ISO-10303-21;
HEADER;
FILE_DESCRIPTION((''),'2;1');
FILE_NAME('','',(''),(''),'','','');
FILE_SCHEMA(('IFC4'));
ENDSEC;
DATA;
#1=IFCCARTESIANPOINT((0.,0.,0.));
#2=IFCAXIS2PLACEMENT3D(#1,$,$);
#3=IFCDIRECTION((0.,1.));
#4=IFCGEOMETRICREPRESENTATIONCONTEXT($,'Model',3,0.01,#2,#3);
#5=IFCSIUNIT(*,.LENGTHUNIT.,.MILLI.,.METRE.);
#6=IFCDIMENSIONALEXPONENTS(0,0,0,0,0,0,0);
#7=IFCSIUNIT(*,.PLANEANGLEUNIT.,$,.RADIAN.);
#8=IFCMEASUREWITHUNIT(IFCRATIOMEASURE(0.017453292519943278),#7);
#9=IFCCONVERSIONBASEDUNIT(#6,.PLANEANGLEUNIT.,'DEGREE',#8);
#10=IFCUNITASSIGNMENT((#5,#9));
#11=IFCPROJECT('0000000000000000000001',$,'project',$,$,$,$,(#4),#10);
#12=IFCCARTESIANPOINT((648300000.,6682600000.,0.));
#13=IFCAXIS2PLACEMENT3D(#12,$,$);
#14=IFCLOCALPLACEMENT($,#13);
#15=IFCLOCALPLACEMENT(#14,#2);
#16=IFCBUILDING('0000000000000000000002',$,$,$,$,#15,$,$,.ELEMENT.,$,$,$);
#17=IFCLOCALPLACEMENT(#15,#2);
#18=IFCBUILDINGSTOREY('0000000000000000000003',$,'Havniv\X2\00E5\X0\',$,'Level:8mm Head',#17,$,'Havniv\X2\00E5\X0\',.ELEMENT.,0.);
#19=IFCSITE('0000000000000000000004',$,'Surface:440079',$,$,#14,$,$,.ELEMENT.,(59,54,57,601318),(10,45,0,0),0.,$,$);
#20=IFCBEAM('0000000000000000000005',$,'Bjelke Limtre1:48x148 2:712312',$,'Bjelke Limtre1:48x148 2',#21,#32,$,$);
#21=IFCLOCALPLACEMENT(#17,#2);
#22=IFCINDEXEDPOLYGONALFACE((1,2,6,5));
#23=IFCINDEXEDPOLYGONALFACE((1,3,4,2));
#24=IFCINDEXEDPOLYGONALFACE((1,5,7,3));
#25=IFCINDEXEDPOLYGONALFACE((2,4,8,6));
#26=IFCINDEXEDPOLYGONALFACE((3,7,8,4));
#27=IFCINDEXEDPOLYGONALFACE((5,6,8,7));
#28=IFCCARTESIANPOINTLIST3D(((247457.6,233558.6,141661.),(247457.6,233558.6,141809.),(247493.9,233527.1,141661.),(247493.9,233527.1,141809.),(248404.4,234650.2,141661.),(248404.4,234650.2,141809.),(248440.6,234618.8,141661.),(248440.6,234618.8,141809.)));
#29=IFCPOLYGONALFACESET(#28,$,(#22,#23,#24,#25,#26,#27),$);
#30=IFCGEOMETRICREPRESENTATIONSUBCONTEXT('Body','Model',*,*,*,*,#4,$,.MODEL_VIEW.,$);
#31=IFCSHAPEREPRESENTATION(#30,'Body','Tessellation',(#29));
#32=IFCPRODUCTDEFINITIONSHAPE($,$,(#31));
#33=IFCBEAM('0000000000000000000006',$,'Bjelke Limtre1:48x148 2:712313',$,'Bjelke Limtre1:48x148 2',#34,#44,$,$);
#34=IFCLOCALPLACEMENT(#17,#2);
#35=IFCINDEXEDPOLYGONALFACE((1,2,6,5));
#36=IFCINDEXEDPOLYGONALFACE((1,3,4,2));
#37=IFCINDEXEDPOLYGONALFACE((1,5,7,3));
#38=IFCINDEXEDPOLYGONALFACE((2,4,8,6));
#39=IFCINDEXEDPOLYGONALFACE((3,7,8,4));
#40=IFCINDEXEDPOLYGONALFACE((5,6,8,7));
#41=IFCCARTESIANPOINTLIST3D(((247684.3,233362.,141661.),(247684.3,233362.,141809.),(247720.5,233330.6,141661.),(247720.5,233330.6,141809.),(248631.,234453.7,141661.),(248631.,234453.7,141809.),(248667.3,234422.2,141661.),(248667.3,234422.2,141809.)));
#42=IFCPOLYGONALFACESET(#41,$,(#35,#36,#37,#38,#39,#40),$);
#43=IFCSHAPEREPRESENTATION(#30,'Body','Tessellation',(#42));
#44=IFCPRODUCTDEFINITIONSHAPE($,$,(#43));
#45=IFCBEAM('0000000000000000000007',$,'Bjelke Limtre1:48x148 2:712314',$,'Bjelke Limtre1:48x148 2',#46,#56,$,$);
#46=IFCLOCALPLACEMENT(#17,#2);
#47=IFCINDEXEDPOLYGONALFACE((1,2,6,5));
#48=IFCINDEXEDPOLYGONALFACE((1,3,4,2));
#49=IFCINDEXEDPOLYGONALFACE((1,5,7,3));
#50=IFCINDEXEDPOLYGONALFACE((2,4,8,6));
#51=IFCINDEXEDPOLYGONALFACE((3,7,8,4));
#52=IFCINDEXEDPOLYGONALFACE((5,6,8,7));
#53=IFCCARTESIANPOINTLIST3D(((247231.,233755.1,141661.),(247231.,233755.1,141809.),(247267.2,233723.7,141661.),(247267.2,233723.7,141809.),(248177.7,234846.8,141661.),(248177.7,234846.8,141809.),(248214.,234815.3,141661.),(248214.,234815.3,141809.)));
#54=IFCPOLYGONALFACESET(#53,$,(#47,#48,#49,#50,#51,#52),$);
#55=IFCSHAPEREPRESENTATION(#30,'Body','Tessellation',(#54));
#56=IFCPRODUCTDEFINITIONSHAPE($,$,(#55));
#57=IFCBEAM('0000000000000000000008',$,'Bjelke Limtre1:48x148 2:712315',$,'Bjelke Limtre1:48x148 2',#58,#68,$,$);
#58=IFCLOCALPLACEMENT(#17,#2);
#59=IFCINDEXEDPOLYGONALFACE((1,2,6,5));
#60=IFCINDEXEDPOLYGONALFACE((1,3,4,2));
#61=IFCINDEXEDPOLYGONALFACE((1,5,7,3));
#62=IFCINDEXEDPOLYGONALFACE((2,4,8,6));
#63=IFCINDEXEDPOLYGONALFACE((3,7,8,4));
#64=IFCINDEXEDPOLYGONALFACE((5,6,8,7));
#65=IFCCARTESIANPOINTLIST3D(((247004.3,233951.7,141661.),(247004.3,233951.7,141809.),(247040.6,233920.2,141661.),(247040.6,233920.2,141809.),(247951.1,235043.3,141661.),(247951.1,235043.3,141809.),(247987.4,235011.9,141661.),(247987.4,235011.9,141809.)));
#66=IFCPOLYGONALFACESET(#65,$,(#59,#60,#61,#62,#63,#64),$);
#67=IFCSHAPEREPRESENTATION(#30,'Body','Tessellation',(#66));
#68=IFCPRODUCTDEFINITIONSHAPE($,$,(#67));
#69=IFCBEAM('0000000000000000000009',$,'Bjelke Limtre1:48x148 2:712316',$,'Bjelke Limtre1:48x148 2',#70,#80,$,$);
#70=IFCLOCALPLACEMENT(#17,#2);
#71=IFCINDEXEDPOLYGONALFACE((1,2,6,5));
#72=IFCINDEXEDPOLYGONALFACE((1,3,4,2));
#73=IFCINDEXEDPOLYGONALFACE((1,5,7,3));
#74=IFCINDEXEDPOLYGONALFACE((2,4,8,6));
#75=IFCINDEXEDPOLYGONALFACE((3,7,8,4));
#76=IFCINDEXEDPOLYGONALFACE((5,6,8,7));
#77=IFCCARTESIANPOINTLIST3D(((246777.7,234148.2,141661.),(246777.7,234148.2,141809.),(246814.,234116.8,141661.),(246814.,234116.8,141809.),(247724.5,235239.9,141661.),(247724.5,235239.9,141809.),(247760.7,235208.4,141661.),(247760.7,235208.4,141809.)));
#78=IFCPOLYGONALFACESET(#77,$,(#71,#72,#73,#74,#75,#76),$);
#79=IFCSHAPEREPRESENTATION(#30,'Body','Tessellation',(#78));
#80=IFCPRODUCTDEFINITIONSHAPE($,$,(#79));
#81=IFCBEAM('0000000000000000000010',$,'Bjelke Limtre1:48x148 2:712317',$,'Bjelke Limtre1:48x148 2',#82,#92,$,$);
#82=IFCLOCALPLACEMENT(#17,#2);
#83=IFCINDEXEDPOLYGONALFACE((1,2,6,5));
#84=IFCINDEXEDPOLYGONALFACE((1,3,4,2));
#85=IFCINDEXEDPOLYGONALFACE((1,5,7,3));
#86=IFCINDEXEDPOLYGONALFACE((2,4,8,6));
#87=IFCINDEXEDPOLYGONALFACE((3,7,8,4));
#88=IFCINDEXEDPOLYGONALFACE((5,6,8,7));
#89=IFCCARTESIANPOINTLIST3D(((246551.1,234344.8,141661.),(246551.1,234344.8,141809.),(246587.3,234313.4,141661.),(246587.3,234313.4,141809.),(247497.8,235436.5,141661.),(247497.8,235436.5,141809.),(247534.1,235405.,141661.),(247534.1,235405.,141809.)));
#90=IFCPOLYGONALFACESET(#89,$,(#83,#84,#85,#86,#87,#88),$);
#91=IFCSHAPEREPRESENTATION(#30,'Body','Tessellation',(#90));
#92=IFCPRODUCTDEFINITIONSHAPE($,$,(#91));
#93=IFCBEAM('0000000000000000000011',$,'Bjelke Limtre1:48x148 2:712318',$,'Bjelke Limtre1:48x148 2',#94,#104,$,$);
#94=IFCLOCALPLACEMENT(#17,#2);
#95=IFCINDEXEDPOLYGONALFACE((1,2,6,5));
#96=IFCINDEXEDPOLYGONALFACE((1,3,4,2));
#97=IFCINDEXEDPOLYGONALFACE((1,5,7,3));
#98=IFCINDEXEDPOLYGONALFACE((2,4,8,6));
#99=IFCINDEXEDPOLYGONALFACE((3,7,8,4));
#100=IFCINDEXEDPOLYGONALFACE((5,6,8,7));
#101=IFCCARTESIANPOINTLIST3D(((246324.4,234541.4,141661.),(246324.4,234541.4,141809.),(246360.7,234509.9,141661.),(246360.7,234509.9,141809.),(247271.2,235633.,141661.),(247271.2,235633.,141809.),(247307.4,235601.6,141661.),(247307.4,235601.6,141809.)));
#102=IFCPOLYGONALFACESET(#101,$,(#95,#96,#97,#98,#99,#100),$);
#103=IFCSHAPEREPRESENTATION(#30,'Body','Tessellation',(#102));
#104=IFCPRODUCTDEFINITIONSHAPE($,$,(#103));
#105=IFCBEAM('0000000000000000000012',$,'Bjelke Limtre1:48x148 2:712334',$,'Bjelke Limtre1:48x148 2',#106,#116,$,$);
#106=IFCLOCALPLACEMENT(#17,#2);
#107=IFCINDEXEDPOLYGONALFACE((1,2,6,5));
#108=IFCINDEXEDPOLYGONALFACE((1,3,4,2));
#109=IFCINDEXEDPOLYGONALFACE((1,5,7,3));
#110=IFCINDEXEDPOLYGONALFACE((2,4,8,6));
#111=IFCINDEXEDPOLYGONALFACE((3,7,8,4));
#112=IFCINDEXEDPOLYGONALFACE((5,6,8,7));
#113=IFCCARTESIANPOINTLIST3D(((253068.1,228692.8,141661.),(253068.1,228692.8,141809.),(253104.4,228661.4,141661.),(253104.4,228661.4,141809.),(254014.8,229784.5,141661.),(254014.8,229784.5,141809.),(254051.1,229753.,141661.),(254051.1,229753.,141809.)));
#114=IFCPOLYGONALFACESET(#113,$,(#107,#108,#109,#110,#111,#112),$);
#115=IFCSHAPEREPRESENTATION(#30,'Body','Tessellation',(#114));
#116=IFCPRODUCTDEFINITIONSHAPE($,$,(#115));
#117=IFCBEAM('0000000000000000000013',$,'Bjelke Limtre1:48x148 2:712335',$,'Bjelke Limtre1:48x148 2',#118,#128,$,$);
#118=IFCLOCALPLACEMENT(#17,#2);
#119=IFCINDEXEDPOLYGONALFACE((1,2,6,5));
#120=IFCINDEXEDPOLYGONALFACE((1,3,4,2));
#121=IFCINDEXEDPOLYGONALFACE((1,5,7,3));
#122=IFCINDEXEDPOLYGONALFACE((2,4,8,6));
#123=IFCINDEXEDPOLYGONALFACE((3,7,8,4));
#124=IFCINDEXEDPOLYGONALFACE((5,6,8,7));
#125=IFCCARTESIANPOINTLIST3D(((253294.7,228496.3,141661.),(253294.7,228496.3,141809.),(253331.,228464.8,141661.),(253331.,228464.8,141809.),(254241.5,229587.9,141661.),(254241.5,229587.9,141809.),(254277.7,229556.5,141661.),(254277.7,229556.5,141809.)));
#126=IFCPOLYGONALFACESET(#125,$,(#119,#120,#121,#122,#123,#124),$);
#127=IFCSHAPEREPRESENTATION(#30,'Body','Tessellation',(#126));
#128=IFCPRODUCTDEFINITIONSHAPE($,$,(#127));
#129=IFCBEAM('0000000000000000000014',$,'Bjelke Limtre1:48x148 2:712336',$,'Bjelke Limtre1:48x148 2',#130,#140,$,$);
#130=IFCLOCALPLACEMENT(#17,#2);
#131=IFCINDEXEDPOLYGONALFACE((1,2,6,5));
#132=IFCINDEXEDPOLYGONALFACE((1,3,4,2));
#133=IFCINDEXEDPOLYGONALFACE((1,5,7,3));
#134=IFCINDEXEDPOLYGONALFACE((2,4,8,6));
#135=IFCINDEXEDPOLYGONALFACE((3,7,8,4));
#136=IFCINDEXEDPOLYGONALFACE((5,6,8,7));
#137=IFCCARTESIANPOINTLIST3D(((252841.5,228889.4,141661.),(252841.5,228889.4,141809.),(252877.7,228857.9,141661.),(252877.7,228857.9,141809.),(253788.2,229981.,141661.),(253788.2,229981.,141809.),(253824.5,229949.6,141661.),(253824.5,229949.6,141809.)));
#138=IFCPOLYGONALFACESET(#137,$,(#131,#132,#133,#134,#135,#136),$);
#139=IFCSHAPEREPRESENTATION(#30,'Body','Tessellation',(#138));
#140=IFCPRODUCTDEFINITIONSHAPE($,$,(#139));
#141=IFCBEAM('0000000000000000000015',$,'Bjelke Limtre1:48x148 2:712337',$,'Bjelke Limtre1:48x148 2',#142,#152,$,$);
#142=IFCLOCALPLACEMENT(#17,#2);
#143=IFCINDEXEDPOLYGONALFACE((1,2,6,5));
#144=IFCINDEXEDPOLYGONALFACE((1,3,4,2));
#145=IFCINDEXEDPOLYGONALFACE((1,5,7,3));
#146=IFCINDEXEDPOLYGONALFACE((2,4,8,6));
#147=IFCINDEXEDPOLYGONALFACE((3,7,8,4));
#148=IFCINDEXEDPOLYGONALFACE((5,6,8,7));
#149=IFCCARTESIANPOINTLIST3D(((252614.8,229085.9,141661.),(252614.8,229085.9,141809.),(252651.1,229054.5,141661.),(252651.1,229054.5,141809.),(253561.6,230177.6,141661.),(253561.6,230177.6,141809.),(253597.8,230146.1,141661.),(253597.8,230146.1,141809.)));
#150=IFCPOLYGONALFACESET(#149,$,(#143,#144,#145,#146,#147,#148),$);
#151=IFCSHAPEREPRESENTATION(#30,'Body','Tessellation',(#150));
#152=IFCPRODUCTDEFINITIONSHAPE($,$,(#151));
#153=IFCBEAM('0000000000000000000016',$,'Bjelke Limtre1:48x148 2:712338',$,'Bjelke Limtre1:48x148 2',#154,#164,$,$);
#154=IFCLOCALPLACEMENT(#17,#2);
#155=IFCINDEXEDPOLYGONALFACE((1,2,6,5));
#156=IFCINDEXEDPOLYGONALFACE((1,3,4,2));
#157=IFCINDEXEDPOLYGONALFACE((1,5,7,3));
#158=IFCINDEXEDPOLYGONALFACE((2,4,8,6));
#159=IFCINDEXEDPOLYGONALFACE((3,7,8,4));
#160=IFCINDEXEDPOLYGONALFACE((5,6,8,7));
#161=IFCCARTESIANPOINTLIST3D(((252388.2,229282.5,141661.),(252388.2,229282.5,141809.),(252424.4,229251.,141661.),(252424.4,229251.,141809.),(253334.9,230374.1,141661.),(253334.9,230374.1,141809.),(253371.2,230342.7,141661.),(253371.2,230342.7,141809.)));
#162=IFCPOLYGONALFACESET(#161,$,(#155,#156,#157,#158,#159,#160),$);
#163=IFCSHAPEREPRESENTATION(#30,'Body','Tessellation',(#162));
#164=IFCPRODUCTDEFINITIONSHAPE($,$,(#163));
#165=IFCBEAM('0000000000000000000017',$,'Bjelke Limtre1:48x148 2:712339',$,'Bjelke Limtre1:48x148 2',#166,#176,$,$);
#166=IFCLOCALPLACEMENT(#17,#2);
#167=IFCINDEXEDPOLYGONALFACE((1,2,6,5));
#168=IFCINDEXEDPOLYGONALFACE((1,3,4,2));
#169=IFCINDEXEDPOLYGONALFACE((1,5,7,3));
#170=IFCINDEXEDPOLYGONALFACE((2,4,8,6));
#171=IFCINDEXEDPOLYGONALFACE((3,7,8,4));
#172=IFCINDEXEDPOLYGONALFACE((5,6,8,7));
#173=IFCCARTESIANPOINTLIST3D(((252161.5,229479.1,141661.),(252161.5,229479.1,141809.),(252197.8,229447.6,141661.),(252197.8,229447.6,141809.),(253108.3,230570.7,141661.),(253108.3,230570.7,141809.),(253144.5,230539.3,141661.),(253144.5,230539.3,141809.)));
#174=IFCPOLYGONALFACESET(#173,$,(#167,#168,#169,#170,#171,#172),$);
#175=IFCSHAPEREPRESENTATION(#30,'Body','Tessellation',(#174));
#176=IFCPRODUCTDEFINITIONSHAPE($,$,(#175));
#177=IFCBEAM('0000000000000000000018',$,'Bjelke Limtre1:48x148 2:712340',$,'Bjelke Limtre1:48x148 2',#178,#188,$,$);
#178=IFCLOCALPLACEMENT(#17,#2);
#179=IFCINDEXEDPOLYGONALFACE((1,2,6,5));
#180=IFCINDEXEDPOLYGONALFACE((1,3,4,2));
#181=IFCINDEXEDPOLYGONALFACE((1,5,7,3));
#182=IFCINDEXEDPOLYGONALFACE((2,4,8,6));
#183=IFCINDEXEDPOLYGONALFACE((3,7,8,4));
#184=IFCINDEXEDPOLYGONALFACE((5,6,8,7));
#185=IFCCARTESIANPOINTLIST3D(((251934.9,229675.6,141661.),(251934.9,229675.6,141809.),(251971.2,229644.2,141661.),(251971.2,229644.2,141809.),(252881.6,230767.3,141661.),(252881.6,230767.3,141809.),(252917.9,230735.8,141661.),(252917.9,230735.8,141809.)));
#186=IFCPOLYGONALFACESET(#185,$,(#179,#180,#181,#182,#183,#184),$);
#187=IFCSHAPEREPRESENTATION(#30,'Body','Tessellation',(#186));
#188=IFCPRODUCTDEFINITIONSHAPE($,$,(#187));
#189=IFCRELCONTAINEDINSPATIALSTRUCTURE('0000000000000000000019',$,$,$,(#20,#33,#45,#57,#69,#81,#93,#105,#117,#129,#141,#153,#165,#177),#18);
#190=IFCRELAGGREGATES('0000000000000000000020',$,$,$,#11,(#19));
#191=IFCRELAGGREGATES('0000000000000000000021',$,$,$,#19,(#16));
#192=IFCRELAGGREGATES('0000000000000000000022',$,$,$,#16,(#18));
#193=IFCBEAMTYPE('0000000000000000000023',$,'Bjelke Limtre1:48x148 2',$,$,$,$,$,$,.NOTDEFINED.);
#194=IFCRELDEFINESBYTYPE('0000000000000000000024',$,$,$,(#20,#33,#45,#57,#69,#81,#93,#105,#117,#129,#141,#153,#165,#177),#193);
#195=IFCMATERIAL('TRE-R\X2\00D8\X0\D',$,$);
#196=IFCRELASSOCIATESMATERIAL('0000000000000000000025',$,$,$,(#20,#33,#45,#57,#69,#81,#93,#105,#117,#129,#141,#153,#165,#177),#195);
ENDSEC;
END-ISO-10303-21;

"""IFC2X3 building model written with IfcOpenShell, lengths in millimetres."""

from ifc_helpers import new_model, entity, si_unit, converted_unit, direction, frame, frame_2d, origin, origin_2d_with_axis, place, context, subcontext, project, spatial, rectangle, extrude, material, type_object, element, save


model = new_model("IFC2X3")

# Units and contexts
model_context = context("Model", 3, precision=0.01, world=origin(), true_north=direction((0.0, 1.0)))
body_context = subcontext(model_context, "Body", "Model", "MODEL_VIEW")
ifc_project = project(units=[si_unit("LENGTHUNIT", "METRE", prefix="MILLI"), converted_unit("PLANEANGLEUNIT", "DEGREE", entity("IfcRatioMeasure", 0.017453292519943278), si_unit("PLANEANGLEUNIT", "RADIAN"), dimensions=[0, 0, 0, 0, 0, 0, 0])], contexts=[model_context])

# Site, building, storey
site_placement = place(None, frame((648300000.0, 6682600000.0, 0.0)))
site = spatial("IfcSite", under=ifc_project, at=site_placement, Name="Surface:440079", CompositionType="ELEMENT", RefLatitude=(59, 54, 57, 601318), RefLongitude=(10, 45, 0, 0), RefElevation=0.0)
building_placement = place(site_placement, origin())
building = spatial("IfcBuilding", under=site, at=building_placement, CompositionType="ELEMENT")
storey_placement = place(building_placement, origin())
storey = spatial("IfcBuildingStorey", under=building, at=storey_placement, Name="Havnivå", ObjectType="Level:8mm Head", LongName="Havnivå", CompositionType="ELEMENT", Elevation=0.0)

# Beams
ifc_material_1 = material(Name="TRE-RØD")
beam_type = type_object("IfcBeamType", Name="Bjelke Limtre1:48x148 2", PredefinedType="NOTDEFINED")
for number, where, z_axis, x_axis, name in (
    (1, (248422.5, 234634.5, 141809.0), (0.0, 0.0, 1.0), (-0.655187, -0.755467, 0.0), "Bjelke Limtre1:48x148 2:712312"),
    (2, (248649.1, 234437.9, 141809.0), (0.0, 0.0, 1.0), (-0.655187, -0.755467, 0.0), "Bjelke Limtre1:48x148 2:712313"),
):
    element("IfcBeam", number, at=place(storey_placement, frame(where, z_axis=z_axis, x_axis=x_axis)), inside=storey, type_object=beam_type, material=ifc_material_1, Name=name, ObjectType="Bjelke Limtre1:48x148 2", context=body_context, shape_type="SweptSolid", body=[
        extrude(rectangle(XDim=148.0, YDim=48.0, at=frame_2d((0.0, 0.0), x_axis=(1.0, 0.0))), frame((0.0, 0.0, -74.0), z_axis=(1.0, 0.0, 0.0), x_axis=(0.0, 0.0, -1.0)), (0.0, 0.0, 1.0), 1445.0),
    ])
beam_1_placement = place(storey_placement, frame((248195.9, 234831.1, 141809.0), z_axis=(0.0, 0.0, 1.0), x_axis=(-0.655187, -0.755467, 0.0)))
element("IfcBeam", 3, at=beam_1_placement, inside=storey, type_object=beam_type, material=ifc_material_1, Name="Bjelke Limtre1:48x148 2:712314", ObjectType="Bjelke Limtre1:48x148 2", context=body_context, shape_type="SweptSolid", body=[
    extrude(rectangle(XDim=148.0, YDim=48.0, at=frame_2d((0.0, 0.0), x_axis=(1.0, 0.0))), frame((0.0, 0.0, -74.0), z_axis=(1.0, 0.0, 0.0), x_axis=(0.0, 0.0, -1.0)), (0.0, 0.0, 1.0), 1445.0),
])
for number, where, z_axis, x_axis, name in (
    (4, (247969.2, 235027.6, 141809.0), (0.0, 0.0, 1.0), (-0.655187, -0.755467, 0.0), "Bjelke Limtre1:48x148 2:712315"),
    (5, (247742.6, 235224.2, 141809.0), (0.0, 0.0, 1.0), (-0.655187, -0.755467, 0.0), "Bjelke Limtre1:48x148 2:712316"),
):
    element("IfcBeam", number, at=place(storey_placement, frame(where, z_axis=z_axis, x_axis=x_axis)), inside=storey, type_object=beam_type, material=ifc_material_1, Name=name, ObjectType="Bjelke Limtre1:48x148 2", context=body_context, shape_type="SweptSolid", body=[
        extrude(rectangle(XDim=148.0, YDim=48.0, at=frame_2d((0.0, 0.0), x_axis=(1.0, 0.0))), frame((0.0, 0.0, -74.0), z_axis=(1.0, 0.0, 0.0), x_axis=(0.0, 0.0, -1.0)), (0.0, 0.0, 1.0), 1445.0),
    ])
beam_2_placement = place(storey_placement, frame((247515.9, 235420.7, 141809.0), z_axis=(0.0, 0.0, 1.0), x_axis=(-0.655187, -0.755467, 0.0)))
element("IfcBeam", 6, at=beam_2_placement, inside=storey, type_object=beam_type, material=ifc_material_1, Name="Bjelke Limtre1:48x148 2:712317", ObjectType="Bjelke Limtre1:48x148 2", context=body_context, shape_type="SweptSolid", body=[
    extrude(rectangle(XDim=148.0, YDim=48.0, at=origin_2d_with_axis()), frame((0.0, 0.0, -74.0), z_axis=(1.0, 0.0, 0.0), x_axis=(0.0, 0.0, -1.0)), (0.0, 0.0, 1.0), 1445.0),
])
beam_3_placement = place(storey_placement, frame((247289.3, 235617.3, 141809.0), z_axis=(0.0, 0.0, 1.0), x_axis=(-0.655187, -0.755467, 0.0)))
element("IfcBeam", 7, at=beam_3_placement, inside=storey, type_object=beam_type, material=ifc_material_1, Name="Bjelke Limtre1:48x148 2:712318", ObjectType="Bjelke Limtre1:48x148 2", context=body_context, shape_type="SweptSolid", body=[
    extrude(rectangle(XDim=148.0, YDim=48.0, at=frame_2d((0.0, 0.0), x_axis=(1.0, 0.0))), frame((0.0, 0.0, -74.0), z_axis=(1.0, 0.0, 0.0), x_axis=(0.0, 0.0, -1.0)), (0.0, 0.0, 1.0), 1445.0),
])
beam_4_placement = place(storey_placement, frame((254033.0, 229768.8, 141809.0), z_axis=(0.0, 0.0, 1.0), x_axis=(-0.655187, -0.755467, 0.0)))
element("IfcBeam", 8, at=beam_4_placement, inside=storey, type_object=beam_type, material=ifc_material_1, Name="Bjelke Limtre1:48x148 2:712334", ObjectType="Bjelke Limtre1:48x148 2", context=body_context, shape_type="SweptSolid", body=[
    extrude(rectangle(XDim=148.0, YDim=48.0, at=frame_2d((0.0, 0.0), x_axis=(1.0, 0.0))), frame((0.0, 0.0, -74.0), z_axis=(1.0, 0.0, 0.0), x_axis=(0.0, 0.0, -1.0)), (0.0, 0.0, 1.0), 1445.0),
])
beam_5_placement = place(storey_placement, frame((254259.6, 229572.2, 141809.0), z_axis=(0.0, 0.0, 1.0), x_axis=(-0.655187, -0.755467, 0.0)))
element("IfcBeam", 9, at=beam_5_placement, inside=storey, type_object=beam_type, material=ifc_material_1, Name="Bjelke Limtre1:48x148 2:712335", ObjectType="Bjelke Limtre1:48x148 2", context=body_context, shape_type="SweptSolid", body=[
    extrude(rectangle(XDim=148.0, YDim=48.0, at=origin_2d_with_axis()), frame((0.0, 0.0, -74.0), z_axis=(1.0, 0.0, 0.0), x_axis=(0.0, 0.0, -1.0)), (0.0, 0.0, 1.0), 1445.0),
])
beam_6_placement = place(storey_placement, frame((253806.3, 229965.3, 141809.0), z_axis=(0.0, 0.0, 1.0), x_axis=(-0.655187, -0.755467, 0.0)))
element("IfcBeam", 10, at=beam_6_placement, inside=storey, type_object=beam_type, material=ifc_material_1, Name="Bjelke Limtre1:48x148 2:712336", ObjectType="Bjelke Limtre1:48x148 2", context=body_context, shape_type="SweptSolid", body=[
    extrude(rectangle(XDim=148.0, YDim=48.0, at=frame_2d((0.0, 0.0), x_axis=(1.0, 0.0))), frame((0.0, 0.0, -74.0), z_axis=(1.0, 0.0, 0.0), x_axis=(0.0, 0.0, -1.0)), (0.0, 0.0, 1.0), 1445.0),
])
beam_7_placement = place(storey_placement, frame((253579.7, 230161.9, 141809.0), z_axis=(0.0, 0.0, 1.0), x_axis=(-0.655187, -0.755467, 0.0)))
element("IfcBeam", 11, at=beam_7_placement, inside=storey, type_object=beam_type, material=ifc_material_1, Name="Bjelke Limtre1:48x148 2:712337", ObjectType="Bjelke Limtre1:48x148 2", context=body_context, shape_type="SweptSolid", body=[
    extrude(rectangle(XDim=148.0, YDim=48.0, at=origin_2d_with_axis()), frame((0.0, 0.0, -74.0), z_axis=(1.0, 0.0, 0.0), x_axis=(0.0, 0.0, -1.0)), (0.0, 0.0, 1.0), 1445.0),
])
beam_8_placement = place(storey_placement, frame((253353.1, 230358.4, 141809.0), z_axis=(0.0, 0.0, 1.0), x_axis=(-0.655187, -0.755467, 0.0)))
element("IfcBeam", 12, at=beam_8_placement, inside=storey, type_object=beam_type, material=ifc_material_1, Name="Bjelke Limtre1:48x148 2:712338", ObjectType="Bjelke Limtre1:48x148 2", context=body_context, shape_type="SweptSolid", body=[
    extrude(rectangle(XDim=148.0, YDim=48.0, at=frame_2d((0.0, 0.0), x_axis=(1.0, 0.0))), frame((0.0, 0.0, -74.0), z_axis=(1.0, 0.0, 0.0), x_axis=(0.0, 0.0, -1.0)), (0.0, 0.0, 1.0), 1445.0),
])
for number, where, z_axis, x_axis, name in (
    (13, (253126.4, 230555.0, 141809.0), (0.0, 0.0, 1.0), (-0.655187, -0.755467, 0.0), "Bjelke Limtre1:48x148 2:712339"),
    (14, (252899.8, 230751.5, 141809.0), (0.0, 0.0, 1.0), (-0.655187, -0.755467, 0.0), "Bjelke Limtre1:48x148 2:712340"),
):
    element("IfcBeam", number, at=place(storey_placement, frame(where, z_axis=z_axis, x_axis=x_axis)), inside=storey, type_object=beam_type, material=ifc_material_1, Name=name, ObjectType="Bjelke Limtre1:48x148 2", context=body_context, shape_type="SweptSolid", body=[
        extrude(rectangle(XDim=148.0, YDim=48.0, at=origin_2d_with_axis()), frame((0.0, 0.0, -74.0), z_axis=(1.0, 0.0, 0.0), x_axis=(0.0, 0.0, -1.0)), (0.0, 0.0, 1.0), 1445.0),
    ])

save(model, "model.ifc")
